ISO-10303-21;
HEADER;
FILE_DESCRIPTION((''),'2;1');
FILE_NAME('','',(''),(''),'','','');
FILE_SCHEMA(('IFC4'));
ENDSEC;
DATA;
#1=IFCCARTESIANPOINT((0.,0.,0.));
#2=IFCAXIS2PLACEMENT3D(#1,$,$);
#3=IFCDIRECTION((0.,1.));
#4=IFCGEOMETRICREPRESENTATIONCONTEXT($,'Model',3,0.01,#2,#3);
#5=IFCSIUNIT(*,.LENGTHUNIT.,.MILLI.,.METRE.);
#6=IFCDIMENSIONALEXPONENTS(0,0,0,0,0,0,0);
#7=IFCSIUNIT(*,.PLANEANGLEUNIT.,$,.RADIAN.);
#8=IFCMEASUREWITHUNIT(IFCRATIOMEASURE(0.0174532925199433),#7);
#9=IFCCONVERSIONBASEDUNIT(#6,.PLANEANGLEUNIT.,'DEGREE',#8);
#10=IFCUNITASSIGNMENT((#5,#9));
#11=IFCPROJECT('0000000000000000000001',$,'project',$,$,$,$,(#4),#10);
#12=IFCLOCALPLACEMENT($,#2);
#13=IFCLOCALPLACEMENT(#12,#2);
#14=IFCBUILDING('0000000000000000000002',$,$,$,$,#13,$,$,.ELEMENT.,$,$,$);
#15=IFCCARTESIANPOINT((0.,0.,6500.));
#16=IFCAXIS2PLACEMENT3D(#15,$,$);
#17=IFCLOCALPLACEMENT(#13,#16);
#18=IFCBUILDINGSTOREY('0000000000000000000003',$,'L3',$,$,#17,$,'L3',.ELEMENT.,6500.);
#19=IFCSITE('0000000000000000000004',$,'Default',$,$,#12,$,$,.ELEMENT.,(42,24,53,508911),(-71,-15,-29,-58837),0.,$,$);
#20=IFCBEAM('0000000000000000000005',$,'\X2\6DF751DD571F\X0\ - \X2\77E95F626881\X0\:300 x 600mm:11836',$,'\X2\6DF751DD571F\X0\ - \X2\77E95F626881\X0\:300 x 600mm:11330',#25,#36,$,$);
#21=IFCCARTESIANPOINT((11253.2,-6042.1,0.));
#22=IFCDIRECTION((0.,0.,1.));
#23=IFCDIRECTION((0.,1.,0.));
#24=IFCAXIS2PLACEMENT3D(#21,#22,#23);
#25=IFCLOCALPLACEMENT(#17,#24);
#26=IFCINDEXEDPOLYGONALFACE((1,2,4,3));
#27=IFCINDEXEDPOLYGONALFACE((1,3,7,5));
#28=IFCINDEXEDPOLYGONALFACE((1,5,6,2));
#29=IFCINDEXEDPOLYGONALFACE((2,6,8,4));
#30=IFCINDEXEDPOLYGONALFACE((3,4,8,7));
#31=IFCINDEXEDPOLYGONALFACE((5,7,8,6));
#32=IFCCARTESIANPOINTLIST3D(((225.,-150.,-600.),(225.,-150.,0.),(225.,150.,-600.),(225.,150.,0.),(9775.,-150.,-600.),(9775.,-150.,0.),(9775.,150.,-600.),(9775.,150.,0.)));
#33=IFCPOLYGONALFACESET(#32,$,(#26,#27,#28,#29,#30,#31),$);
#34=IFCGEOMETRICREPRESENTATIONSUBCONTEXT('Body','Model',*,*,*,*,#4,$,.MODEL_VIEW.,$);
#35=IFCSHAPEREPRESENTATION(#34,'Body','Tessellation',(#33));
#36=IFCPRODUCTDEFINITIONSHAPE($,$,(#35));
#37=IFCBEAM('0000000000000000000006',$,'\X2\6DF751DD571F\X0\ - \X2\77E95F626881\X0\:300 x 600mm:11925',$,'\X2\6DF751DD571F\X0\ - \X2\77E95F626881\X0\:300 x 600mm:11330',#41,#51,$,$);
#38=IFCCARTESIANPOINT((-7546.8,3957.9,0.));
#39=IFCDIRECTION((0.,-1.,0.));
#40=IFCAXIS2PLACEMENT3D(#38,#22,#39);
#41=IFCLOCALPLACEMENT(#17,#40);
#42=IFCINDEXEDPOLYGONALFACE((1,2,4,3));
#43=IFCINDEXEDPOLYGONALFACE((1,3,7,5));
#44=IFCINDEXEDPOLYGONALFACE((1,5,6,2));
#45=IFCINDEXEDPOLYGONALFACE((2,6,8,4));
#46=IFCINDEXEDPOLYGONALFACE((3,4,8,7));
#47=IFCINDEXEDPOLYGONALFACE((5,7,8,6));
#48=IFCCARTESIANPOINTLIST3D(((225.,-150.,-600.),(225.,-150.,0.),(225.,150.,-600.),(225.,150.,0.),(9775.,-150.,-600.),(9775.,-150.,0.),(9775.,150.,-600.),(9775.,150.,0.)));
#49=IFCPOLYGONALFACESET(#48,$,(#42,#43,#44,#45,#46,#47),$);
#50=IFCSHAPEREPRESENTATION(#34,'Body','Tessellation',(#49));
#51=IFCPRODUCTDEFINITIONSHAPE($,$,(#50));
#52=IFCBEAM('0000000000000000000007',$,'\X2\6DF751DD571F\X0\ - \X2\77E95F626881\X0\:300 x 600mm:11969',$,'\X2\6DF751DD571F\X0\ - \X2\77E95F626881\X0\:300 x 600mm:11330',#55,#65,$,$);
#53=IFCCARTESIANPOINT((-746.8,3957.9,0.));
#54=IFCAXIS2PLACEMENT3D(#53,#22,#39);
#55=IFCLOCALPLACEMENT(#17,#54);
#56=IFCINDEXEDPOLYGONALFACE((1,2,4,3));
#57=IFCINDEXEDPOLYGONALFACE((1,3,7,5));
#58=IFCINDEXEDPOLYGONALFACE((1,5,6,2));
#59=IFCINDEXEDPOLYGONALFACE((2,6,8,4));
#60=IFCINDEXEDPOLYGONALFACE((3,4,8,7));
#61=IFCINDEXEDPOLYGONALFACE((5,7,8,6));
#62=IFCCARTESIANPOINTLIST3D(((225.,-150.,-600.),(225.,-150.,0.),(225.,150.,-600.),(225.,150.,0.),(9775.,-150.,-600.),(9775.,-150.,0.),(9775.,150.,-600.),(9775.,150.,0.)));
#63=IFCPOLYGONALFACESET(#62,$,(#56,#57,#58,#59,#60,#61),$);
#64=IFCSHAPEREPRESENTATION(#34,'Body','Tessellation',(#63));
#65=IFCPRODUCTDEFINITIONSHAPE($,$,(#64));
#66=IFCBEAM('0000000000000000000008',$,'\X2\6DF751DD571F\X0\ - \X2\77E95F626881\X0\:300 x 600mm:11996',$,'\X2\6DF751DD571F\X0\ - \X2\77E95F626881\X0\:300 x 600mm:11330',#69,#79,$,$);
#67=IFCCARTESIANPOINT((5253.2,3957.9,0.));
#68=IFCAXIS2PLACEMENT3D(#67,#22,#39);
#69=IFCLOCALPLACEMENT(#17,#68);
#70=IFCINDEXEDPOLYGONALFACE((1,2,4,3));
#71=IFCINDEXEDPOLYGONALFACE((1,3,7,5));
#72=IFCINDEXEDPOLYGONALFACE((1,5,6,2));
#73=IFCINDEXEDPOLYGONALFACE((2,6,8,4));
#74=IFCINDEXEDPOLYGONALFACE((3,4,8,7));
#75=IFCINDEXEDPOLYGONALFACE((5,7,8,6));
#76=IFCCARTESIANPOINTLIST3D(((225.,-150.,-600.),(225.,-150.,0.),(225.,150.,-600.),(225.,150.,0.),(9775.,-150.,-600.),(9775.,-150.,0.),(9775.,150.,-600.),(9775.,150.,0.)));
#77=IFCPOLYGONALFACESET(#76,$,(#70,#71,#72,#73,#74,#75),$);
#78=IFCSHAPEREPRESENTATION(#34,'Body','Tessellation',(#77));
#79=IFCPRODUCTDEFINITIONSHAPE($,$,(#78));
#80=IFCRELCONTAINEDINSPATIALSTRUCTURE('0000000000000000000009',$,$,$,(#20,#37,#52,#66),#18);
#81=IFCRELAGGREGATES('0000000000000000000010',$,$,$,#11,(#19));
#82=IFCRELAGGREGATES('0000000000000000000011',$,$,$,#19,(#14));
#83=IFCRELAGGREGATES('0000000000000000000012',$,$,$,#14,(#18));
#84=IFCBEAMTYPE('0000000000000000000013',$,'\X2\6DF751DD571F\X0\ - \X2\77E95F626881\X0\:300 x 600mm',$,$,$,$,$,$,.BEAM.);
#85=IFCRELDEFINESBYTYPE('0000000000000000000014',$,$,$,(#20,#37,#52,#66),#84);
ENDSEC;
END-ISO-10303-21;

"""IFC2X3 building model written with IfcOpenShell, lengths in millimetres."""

from ifc_helpers import new_model, entity, si_unit, converted_unit, direction, frame, frame_2d, origin, origin_2d_with_axis, place, context, subcontext, project, spatial, rectangle, extrude, type_object, element, save


model = new_model("IFC2X3")

# Units and contexts
model_context = context("Model", 3, precision=0.01, world=origin(), true_north=direction((0.0, 1.0)))
body_context = subcontext(model_context, "Body", "Model", "MODEL_VIEW")
ifc_project = project(units=[si_unit("LENGTHUNIT", "METRE", prefix="MILLI"), converted_unit("PLANEANGLEUNIT", "DEGREE", entity("IfcRatioMeasure", 0.0174532925199433), si_unit("PLANEANGLEUNIT", "RADIAN"), dimensions=[0, 0, 0, 0, 0, 0, 0])], contexts=[model_context])

# Site, building, storey
site_placement = place(None, origin())
site = spatial("IfcSite", under=ifc_project, at=site_placement, Name="Default", CompositionType="ELEMENT", RefLatitude=(42, 24, 53, 508911), RefLongitude=(-71, -15, -29, -58837), RefElevation=0.0)
building_placement = place(site_placement, origin())
building = spatial("IfcBuilding", under=site, at=building_placement, CompositionType="ELEMENT")
storey_placement = place(building_placement, frame((0.0, 0.0, 6500.0)))
storey = spatial("IfcBuildingStorey", under=building, at=storey_placement, Name="L3", LongName="L3", CompositionType="ELEMENT", Elevation=6500.0)

# Beams
beam_type_1 = type_object("IfcBeamType", Name="混凝土 - 矩形梁:300 x 600mm", PredefinedType="BEAM")
beam_1_placement = place(storey_placement, frame((11253.2, -6042.1, 0.0), z_axis=(0.0, 0.0, 1.0), x_axis=(0.0, 1.0, 0.0)))
element("IfcBeam", 1, at=beam_1_placement, inside=storey, type_object=beam_type_1, Name="混凝土 - 矩形梁:300 x 600mm:11836", ObjectType="混凝土 - 矩形梁:300 x 600mm:11330", context=body_context, shape_type="SweptSolid", body=[
    extrude(rectangle(XDim=600.0, YDim=300.0, at=frame_2d((0.0, 0.0), x_axis=(1.0, 0.0))), frame((225.0, 0.0, -300.0), z_axis=(1.0, 0.0, 0.0), x_axis=(0.0, 0.0, -1.0)), (0.0, 0.0, 1.0), 9550.0),
])
beam_2_placement = place(storey_placement, frame((-7546.8, 3957.9, 0.0), z_axis=(0.0, 0.0, 1.0), x_axis=(0.0, -1.0, 0.0)))
element("IfcBeam", 2, at=beam_2_placement, inside=storey, type_object=beam_type_1, Name="混凝土 - 矩形梁:300 x 600mm:11925", ObjectType="混凝土 - 矩形梁:300 x 600mm:11330", context=body_context, shape_type="SweptSolid", body=[
    extrude(rectangle(XDim=600.0, YDim=300.0, at=origin_2d_with_axis()), frame((225.0, 0.0, -300.0), z_axis=(1.0, 0.0, 0.0), x_axis=(0.0, 0.0, -1.0)), (0.0, 0.0, 1.0), 9550.0),
])
beam_3_placement = place(storey_placement, frame((-746.8, 3957.9, 0.0), z_axis=(0.0, 0.0, 1.0), x_axis=(0.0, -1.0, 0.0)))
element("IfcBeam", 3, at=beam_3_placement, inside=storey, type_object=beam_type_1, Name="混凝土 - 矩形梁:300 x 600mm:11969", ObjectType="混凝土 - 矩形梁:300 x 600mm:11330", context=body_context, shape_type="SweptSolid", body=[
    extrude(rectangle(XDim=600.0, YDim=300.0, at=frame_2d((0.0, 0.0), x_axis=(1.0, 0.0))), frame((225.0, 0.0, -300.0), z_axis=(1.0, 0.0, 0.0), x_axis=(0.0, 0.0, -1.0)), (0.0, 0.0, 1.0), 9550.0),
])
beam_4_placement = place(storey_placement, frame((5253.2, 3957.9, 0.0), z_axis=(0.0, 0.0, 1.0), x_axis=(0.0, -1.0, 0.0)))
element("IfcBeam", 4, at=beam_4_placement, inside=storey, type_object=beam_type_1, Name="混凝土 - 矩形梁:300 x 600mm:11996", ObjectType="混凝土 - 矩形梁:300 x 600mm:11330", context=body_context, shape_type="SweptSolid", body=[
    extrude(rectangle(XDim=600.0, YDim=300.0, at=origin_2d_with_axis()), frame((225.0, 0.0, -300.0), z_axis=(1.0, 0.0, 0.0), x_axis=(0.0, 0.0, -1.0)), (0.0, 0.0, 1.0), 9550.0),
])

save(model, "model.ifc")
